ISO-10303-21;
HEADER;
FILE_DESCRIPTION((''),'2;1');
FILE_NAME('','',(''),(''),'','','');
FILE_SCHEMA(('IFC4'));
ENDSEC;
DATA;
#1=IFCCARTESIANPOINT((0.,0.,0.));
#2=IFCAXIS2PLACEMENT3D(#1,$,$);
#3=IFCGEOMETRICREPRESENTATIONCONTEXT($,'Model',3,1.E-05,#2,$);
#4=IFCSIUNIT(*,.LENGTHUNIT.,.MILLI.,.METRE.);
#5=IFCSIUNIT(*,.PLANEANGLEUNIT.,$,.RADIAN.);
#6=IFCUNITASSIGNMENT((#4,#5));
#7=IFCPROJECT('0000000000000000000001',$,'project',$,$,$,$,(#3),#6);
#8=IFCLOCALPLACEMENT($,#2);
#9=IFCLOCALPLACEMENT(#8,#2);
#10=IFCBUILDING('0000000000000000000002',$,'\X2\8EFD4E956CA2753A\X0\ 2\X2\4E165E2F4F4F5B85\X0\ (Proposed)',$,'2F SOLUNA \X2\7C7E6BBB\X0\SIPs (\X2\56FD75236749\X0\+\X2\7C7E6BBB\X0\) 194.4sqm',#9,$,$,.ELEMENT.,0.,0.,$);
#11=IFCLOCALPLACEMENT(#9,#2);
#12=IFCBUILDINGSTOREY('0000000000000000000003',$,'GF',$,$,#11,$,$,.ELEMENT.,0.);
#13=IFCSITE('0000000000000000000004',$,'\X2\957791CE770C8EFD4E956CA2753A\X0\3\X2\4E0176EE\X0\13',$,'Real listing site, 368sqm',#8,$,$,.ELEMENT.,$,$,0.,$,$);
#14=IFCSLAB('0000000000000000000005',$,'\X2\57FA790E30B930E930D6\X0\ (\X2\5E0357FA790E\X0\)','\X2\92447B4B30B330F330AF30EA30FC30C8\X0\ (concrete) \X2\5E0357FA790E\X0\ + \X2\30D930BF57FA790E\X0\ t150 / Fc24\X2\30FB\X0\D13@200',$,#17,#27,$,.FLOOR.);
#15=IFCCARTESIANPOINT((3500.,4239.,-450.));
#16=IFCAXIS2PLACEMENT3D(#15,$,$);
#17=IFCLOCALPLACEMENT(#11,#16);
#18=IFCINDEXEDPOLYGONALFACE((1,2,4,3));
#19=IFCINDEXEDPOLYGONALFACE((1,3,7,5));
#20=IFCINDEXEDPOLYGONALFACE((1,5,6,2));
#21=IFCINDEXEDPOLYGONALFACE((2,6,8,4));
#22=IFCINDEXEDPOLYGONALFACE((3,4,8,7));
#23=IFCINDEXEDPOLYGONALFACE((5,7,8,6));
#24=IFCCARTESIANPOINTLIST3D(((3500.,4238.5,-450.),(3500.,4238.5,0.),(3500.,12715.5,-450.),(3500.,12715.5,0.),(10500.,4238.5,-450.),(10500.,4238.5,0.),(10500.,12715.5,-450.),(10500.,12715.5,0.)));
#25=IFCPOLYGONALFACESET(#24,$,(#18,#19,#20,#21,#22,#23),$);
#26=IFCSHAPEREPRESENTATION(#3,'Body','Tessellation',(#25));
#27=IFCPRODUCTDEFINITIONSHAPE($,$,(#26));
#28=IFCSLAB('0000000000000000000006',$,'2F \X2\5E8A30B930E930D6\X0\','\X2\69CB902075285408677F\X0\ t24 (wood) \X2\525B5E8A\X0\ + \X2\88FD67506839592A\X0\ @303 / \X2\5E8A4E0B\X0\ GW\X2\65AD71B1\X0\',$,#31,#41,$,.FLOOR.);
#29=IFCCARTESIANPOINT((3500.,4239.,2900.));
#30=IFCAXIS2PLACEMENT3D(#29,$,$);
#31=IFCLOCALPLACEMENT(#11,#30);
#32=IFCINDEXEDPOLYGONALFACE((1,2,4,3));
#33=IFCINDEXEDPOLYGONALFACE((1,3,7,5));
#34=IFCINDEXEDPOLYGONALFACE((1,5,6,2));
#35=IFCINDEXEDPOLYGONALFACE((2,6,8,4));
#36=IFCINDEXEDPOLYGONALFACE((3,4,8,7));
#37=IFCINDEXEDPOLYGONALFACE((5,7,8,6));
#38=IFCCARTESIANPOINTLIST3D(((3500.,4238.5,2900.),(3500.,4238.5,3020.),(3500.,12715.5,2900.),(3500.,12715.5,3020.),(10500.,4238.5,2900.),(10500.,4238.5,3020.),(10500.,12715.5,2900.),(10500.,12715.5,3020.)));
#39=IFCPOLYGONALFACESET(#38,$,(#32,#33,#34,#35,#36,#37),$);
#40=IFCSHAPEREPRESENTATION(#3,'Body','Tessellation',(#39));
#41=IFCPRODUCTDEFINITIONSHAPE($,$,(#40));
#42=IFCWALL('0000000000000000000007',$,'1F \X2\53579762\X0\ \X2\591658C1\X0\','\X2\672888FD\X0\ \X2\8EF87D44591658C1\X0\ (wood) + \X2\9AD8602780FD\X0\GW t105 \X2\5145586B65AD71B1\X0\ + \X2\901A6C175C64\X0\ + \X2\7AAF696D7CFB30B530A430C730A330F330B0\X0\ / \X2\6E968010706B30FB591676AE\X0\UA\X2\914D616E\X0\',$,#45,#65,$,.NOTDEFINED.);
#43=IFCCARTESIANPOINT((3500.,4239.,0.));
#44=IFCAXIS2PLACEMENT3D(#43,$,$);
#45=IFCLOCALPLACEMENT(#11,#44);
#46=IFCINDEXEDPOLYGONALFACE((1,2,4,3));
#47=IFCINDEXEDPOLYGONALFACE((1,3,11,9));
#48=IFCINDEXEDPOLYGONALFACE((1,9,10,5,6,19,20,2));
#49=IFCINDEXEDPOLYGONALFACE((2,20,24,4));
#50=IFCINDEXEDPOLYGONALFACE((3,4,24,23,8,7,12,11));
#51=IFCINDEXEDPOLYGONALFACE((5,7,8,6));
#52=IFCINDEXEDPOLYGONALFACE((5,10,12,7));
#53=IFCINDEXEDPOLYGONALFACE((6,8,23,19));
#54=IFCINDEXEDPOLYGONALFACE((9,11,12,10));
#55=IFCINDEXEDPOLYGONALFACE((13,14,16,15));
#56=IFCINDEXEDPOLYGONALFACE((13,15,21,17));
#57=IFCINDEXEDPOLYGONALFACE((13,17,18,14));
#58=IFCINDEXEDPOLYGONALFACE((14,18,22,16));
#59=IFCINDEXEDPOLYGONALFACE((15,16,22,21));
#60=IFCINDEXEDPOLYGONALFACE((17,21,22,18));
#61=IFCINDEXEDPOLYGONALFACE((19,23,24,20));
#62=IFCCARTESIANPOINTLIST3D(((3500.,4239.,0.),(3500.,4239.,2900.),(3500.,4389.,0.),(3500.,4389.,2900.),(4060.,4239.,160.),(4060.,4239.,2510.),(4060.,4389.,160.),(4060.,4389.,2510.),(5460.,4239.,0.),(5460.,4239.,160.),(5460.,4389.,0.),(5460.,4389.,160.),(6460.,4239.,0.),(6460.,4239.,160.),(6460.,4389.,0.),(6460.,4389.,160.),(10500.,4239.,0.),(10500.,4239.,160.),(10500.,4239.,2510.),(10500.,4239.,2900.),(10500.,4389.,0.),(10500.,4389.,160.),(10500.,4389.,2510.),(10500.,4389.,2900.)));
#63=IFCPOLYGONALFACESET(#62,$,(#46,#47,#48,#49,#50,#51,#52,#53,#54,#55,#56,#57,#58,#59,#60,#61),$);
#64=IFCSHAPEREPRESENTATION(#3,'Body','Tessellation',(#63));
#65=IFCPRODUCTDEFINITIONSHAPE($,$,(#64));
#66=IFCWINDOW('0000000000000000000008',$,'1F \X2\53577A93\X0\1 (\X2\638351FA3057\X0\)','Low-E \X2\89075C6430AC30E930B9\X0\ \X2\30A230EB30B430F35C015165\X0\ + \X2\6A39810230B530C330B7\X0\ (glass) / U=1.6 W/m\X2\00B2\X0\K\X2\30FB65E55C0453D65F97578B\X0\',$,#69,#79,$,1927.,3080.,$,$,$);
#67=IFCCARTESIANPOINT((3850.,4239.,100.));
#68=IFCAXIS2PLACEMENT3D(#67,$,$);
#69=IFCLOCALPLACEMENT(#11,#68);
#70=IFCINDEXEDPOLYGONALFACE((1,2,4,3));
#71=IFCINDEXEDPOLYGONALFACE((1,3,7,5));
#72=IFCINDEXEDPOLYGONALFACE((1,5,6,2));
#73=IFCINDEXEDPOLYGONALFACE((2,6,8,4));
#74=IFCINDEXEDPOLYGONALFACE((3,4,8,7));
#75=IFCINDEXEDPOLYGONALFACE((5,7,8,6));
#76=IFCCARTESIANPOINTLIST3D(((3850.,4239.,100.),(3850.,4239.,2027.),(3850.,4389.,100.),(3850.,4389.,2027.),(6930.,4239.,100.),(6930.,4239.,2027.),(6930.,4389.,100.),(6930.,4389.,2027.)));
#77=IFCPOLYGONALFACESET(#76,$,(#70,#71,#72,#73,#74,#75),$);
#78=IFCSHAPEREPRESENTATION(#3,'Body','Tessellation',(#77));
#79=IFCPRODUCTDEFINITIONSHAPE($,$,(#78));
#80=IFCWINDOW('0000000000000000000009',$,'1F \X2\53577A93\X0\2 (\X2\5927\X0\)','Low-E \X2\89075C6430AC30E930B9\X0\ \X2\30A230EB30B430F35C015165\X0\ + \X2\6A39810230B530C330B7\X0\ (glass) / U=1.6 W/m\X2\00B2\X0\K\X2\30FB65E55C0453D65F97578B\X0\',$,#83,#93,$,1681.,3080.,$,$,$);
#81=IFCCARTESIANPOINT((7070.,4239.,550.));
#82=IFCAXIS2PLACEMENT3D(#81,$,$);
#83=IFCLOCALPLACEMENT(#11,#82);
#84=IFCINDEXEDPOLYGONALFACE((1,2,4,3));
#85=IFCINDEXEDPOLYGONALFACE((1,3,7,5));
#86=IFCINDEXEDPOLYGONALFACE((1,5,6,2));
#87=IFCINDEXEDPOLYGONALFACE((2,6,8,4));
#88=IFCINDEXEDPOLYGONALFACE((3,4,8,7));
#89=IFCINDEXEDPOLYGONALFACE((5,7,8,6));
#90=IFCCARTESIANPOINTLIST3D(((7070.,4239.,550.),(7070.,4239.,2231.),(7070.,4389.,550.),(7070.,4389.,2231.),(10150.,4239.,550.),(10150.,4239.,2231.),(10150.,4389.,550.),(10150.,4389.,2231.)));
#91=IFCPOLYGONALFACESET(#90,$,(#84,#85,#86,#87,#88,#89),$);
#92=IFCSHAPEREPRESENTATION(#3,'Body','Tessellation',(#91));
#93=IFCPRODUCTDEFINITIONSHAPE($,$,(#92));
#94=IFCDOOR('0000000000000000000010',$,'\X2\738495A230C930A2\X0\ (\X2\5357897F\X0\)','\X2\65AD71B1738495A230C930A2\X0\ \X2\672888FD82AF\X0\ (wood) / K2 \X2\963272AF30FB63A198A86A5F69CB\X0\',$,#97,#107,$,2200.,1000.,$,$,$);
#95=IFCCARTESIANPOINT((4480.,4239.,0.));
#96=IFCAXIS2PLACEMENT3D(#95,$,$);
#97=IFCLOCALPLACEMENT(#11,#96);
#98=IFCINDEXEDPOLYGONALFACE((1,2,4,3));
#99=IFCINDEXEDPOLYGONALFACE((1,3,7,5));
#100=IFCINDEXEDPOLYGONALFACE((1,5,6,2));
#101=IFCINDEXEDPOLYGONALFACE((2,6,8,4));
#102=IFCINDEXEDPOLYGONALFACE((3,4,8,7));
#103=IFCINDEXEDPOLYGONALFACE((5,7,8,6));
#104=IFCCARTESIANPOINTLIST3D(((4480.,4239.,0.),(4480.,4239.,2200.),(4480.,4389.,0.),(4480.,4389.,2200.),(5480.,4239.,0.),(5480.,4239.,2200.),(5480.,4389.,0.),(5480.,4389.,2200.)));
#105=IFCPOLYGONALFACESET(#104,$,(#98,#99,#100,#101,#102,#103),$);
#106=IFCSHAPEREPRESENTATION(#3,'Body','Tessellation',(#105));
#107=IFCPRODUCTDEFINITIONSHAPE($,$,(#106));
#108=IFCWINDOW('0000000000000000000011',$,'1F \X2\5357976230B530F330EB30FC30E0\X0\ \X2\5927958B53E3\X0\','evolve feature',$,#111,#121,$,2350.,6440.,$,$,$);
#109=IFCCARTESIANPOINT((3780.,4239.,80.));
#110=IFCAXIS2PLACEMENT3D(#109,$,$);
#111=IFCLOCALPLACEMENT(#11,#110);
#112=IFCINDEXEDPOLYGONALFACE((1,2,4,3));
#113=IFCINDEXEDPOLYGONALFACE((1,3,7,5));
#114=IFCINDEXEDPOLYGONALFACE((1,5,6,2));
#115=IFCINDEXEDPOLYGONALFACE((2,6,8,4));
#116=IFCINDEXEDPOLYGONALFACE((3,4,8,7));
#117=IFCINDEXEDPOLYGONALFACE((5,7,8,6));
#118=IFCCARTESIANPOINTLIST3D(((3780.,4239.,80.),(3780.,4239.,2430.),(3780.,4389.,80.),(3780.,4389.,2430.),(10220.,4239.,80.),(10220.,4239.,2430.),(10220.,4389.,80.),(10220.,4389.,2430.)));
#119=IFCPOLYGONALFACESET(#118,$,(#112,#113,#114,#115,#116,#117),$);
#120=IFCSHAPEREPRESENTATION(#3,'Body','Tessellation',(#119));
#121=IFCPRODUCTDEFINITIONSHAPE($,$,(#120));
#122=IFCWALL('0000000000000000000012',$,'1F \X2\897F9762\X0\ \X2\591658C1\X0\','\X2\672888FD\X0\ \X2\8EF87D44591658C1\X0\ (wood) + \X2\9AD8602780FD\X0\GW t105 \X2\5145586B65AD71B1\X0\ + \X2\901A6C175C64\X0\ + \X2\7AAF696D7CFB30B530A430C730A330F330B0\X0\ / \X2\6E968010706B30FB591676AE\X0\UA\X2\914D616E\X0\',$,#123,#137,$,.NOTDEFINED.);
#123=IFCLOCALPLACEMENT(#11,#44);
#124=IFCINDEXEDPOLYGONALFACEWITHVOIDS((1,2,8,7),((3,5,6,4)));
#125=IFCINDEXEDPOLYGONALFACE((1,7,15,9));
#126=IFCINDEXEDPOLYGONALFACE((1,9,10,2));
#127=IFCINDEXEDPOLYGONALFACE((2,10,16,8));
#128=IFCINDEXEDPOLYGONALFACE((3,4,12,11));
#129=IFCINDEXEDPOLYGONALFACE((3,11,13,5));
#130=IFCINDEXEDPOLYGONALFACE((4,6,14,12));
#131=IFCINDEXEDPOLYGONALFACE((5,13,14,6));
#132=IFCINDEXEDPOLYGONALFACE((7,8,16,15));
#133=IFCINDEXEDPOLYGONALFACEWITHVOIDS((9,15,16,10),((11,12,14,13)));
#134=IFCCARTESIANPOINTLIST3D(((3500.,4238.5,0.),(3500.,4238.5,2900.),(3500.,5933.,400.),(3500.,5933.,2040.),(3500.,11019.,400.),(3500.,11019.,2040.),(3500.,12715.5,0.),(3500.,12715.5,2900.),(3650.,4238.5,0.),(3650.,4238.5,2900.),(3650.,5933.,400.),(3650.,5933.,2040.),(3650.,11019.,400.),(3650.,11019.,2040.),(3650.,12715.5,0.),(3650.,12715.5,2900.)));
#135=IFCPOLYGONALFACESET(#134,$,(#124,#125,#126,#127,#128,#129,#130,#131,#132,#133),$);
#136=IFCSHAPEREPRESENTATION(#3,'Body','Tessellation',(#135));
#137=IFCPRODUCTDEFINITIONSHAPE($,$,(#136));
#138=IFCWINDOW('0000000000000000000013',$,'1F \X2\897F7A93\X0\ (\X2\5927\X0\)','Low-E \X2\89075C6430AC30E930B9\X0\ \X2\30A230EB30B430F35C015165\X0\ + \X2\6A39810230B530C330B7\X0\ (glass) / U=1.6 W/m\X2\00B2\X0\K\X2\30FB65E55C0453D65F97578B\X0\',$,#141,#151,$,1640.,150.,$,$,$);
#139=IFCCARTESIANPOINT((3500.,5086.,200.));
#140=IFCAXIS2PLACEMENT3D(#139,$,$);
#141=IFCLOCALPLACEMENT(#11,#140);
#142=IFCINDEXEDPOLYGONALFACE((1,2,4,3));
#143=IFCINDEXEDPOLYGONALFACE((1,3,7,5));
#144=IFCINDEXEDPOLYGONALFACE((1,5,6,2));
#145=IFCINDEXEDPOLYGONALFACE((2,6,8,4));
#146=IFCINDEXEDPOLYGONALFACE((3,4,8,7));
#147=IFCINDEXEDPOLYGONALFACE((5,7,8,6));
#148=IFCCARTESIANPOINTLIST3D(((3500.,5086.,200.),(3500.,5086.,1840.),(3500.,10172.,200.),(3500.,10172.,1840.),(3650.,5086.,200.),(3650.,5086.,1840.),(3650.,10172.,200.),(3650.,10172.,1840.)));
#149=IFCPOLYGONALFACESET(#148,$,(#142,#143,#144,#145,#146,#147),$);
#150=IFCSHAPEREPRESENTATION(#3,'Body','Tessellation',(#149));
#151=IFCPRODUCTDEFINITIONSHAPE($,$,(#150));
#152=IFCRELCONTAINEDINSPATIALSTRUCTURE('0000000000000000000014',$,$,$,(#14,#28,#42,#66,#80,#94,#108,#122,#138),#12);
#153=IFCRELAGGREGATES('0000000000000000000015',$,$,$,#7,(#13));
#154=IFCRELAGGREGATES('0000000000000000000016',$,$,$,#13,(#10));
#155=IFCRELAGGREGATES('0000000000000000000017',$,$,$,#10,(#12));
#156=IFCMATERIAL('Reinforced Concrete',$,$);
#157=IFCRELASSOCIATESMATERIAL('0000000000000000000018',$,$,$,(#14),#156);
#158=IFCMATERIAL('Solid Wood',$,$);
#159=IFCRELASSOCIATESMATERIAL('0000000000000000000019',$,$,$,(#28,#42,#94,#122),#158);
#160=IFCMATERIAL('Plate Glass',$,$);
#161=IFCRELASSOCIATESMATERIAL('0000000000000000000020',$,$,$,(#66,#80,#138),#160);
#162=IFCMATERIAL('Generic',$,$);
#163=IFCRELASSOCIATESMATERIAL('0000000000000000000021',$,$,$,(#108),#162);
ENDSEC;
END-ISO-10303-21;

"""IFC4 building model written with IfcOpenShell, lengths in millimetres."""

from ifc_helpers import new_model, si_unit, frame, frame_2d, origin, place, context, project, spatial, rectangle, extrude, material, element, fill, save


model = new_model("IFC4")

# Units and contexts
model_context = context("Model", 3, precision=1e-05, world=origin())
ifc_project = project(units=[si_unit("LENGTHUNIT", "METRE", prefix="MILLI"), si_unit("PLANEANGLEUNIT", "RADIAN")], contexts=[model_context])

# Site, building, storey
site_placement = place(None, origin())
site = spatial("IfcSite", under=ifc_project, at=site_placement, Name="長野県軽井沢町3丁目13", ObjectType="Real listing site, 368sqm", CompositionType="ELEMENT", RefElevation=0.0)
building_placement = place(site_placement, origin())
building = spatial("IfcBuilding", under=site, at=building_placement, Name="軽井沢町 2世帯住宅 (Proposed)", ObjectType="2F SOLUNA 籾殻SIPs (国産杉+籾殻) 194.4sqm", CompositionType="ELEMENT", ElevationOfRefHeight=0.0, ElevationOfTerrain=0.0)
storey_placement = place(building_placement, origin())
storey = spatial("IfcBuildingStorey", under=building, at=storey_placement, Name="GF", CompositionType="ELEMENT", Elevation=0.0)

# Slabs
ifc_material_1 = material(Name="Reinforced Concrete")
slab_1_placement = place(storey_placement, frame((3500.0, 4239.0, -450.0)))
element("IfcSlab", 1, at=slab_1_placement, inside=storey, material=ifc_material_1, Name="基礎スラブ (布基礎)", Description="鉄筋コンクリート (concrete) 布基礎 + ベタ基礎 t150 / Fc24・D13@200", PredefinedType="FLOOR", context=model_context, shape_type="SweptSolid", body=[
    extrude(rectangle(XDim=7000.0, YDim=8477.0, at=frame_2d((3500.0, 4238.0))), frame((3500.0, 4239.0, -450.0)), (0.0, 0.0, 1.0), 450.0),
])
ifc_material_2 = material(Name="Solid Wood")
slab_2_placement = place(storey_placement, frame((3500.0, 4239.0, 2900.0)))
element("IfcSlab", 2, at=slab_2_placement, inside=storey, material=ifc_material_2, Name="2F 床スラブ", Description="構造用合板 t24 (wood) 剛床 + 製材根太 @303 / 床下 GW断熱", PredefinedType="FLOOR", context=model_context, shape_type="SweptSolid", body=[
    extrude(rectangle(XDim=7000.0, YDim=8477.0, at=frame_2d((3500.0, 4238.0))), frame((3500.0, 4239.0, 2900.0)), (0.0, 0.0, 1.0), 120.0),
])
ifc_material_3 = material(Name="Generic")

# Wall, openings, windows, door
wall_1_placement = place(storey_placement, frame((3500.0, 4239.0, 0.0)))
wall_1 = element("IfcWall", 3, at=wall_1_placement, inside=storey, material=ifc_material_2, Name="1F 南面 外壁", Description="木製 軸組外壁 (wood) + 高性能GW t105 充填断熱 + 通気層 + 窯業系サイディング / 準耐火・外皮UA配慮", PredefinedType="NOTDEFINED", context=model_context, shape_type="SweptSolid", body=[
    extrude(rectangle(XDim=7000.0, YDim=150.0, at=frame_2d((3500.0, 75.0))), frame((3500.0, 4239.0, 0.0)), (0.0, 0.0, 1.0), 2900.0),
])
opening_1_placement = place(storey_placement, frame((3850.0, 4239.0, 100.0)))
opening_1 = element("IfcOpeningElement", 4, at=opening_1_placement, cuts=wall_1, PredefinedType="NOTDEFINED", context=model_context, shape_type="SweptSolid", body=[
    extrude(rectangle(XDim=3080.0, YDim=150.0, at=frame_2d((1540.0, 75.0))), frame((3850.0, 4239.0, 100.0)), (0.0, 0.0, 1.0), 1927.0),
])
opening_2_placement = place(storey_placement, frame((7070.0, 4239.0, 550.0)))
opening_2 = element("IfcOpeningElement", 5, at=opening_2_placement, cuts=wall_1, PredefinedType="NOTDEFINED", context=model_context, shape_type="SweptSolid", body=[
    extrude(rectangle(XDim=3080.0, YDim=150.0, at=frame_2d((1540.0, 75.0))), frame((7070.0, 4239.0, 550.0)), (0.0, 0.0, 1.0), 1681.0),
])
opening_3_placement = place(storey_placement, frame((4480.0, 4239.0, 0.0)))
opening_3 = element("IfcOpeningElement", 6, at=opening_3_placement, cuts=wall_1, PredefinedType="NOTDEFINED", context=model_context, shape_type="SweptSolid", body=[
    extrude(rectangle(XDim=1000.0, YDim=150.0, at=frame_2d((500.0, 75.0))), frame((4480.0, 4239.0, 0.0)), (0.0, 0.0, 1.0), 2200.0),
])
opening_4_placement = place(storey_placement, frame((3780.0, 4239.0, 80.0)))
opening_4 = element("IfcOpeningElement", 7, at=opening_4_placement, cuts=wall_1, PredefinedType="NOTDEFINED", context=model_context, shape_type="SweptSolid", body=[
    extrude(rectangle(XDim=6440.0, YDim=150.0, at=frame_2d((3220.0, 75.0))), frame((3780.0, 4239.0, 80.0)), (0.0, 0.0, 1.0), 2350.0),
])
ifc_material_4 = material(Name="Plate Glass")
window_1_placement = place(storey_placement, frame((3850.0, 4239.0, 100.0)))
window_1 = element("IfcWindow", 8, at=window_1_placement, inside=storey, material=ifc_material_4, Name="1F 南窓1 (掃出し)", Description="Low-E 複層ガラス アルゴン封入 + 樹脂サッシ (glass) / U=1.6 W/m²K・日射取得型", OverallHeight=1927.0, OverallWidth=3080.0, context=model_context, shape_type="SweptSolid", body=[
    extrude(rectangle(XDim=3080.0, YDim=150.0, at=frame_2d((1540.0, 75.0))), frame((3850.0, 4239.0, 100.0)), (0.0, 0.0, 1.0), 1927.0),
])
fill(opening_1, window_1)
window_2_placement = place(storey_placement, frame((7070.0, 4239.0, 550.0)))
window_2 = element("IfcWindow", 9, at=window_2_placement, inside=storey, material=ifc_material_4, Name="1F 南窓2 (大)", Description="Low-E 複層ガラス アルゴン封入 + 樹脂サッシ (glass) / U=1.6 W/m²K・日射取得型", OverallHeight=1681.0, OverallWidth=3080.0, context=model_context, shape_type="SweptSolid", body=[
    extrude(rectangle(XDim=3080.0, YDim=150.0, at=frame_2d((1540.0, 75.0))), frame((7070.0, 4239.0, 550.0)), (0.0, 0.0, 1.0), 1681.0),
])
fill(opening_2, window_2)
door_placement = place(storey_placement, frame((4480.0, 4239.0, 0.0)))
door = element("IfcDoor", 10, at=door_placement, inside=storey, material=ifc_material_2, Name="玄関ドア (南西)", Description="断熱玄関ドア 木製芯 (wood) / K2 防犯・採風機構", OverallHeight=2200.0, OverallWidth=1000.0, context=model_context, shape_type="SweptSolid", body=[
    extrude(rectangle(XDim=1000.0, YDim=150.0, at=frame_2d((500.0, 75.0))), frame((4480.0, 4239.0, 0.0)), (0.0, 0.0, 1.0), 2200.0),
])
fill(opening_3, door)
window_3_placement = place(storey_placement, frame((3780.0, 4239.0, 80.0)))
window_3 = element("IfcWindow", 11, at=window_3_placement, inside=storey, material=ifc_material_3, Name="1F 南面サンルーム 大開口", Description="evolve feature", OverallHeight=2350.0, OverallWidth=6440.0, context=model_context, shape_type="SweptSolid", body=[
    extrude(rectangle(XDim=6440.0, YDim=150.0, at=frame_2d((3220.0, 75.0))), frame((3780.0, 4239.0, 80.0)), (0.0, 0.0, 1.0), 2350.0),
])
fill(opening_4, window_3)

# Wall, opening, window
wall_2_placement = place(storey_placement, frame((3500.0, 4239.0, 0.0)))
wall_2 = element("IfcWall", 12, at=wall_2_placement, inside=storey, material=ifc_material_2, Name="1F 西面 外壁", Description="木製 軸組外壁 (wood) + 高性能GW t105 充填断熱 + 通気層 + 窯業系サイディング / 準耐火・外皮UA配慮", PredefinedType="NOTDEFINED", context=model_context, shape_type="SweptSolid", body=[
    extrude(rectangle(XDim=150.0, YDim=8477.0, at=frame_2d((75.0, 4238.0))), frame((3500.0, 4239.0, 0.0)), (0.0, 0.0, 1.0), 2900.0),
])
opening_5_placement = place(storey_placement, frame((3500.0, 5086.0, 200.0)))
opening_5 = element("IfcOpeningElement", 13, at=opening_5_placement, cuts=wall_2, PredefinedType="NOTDEFINED", context=model_context, shape_type="SweptSolid", body=[
    extrude(rectangle(XDim=150.0, YDim=5086.0, at=frame_2d((75.0, 2543.0))), frame((3500.0, 5086.0, 200.0)), (0.0, 0.0, 1.0), 1640.0),
])
window_4_placement = place(storey_placement, frame((3500.0, 5086.0, 200.0)))
window_4 = element("IfcWindow", 14, at=window_4_placement, inside=storey, material=ifc_material_4, Name="1F 西窓 (大)", Description="Low-E 複層ガラス アルゴン封入 + 樹脂サッシ (glass) / U=1.6 W/m²K・日射取得型", OverallHeight=1640.0, OverallWidth=150.0, context=model_context, shape_type="SweptSolid", body=[
    extrude(rectangle(XDim=150.0, YDim=5086.0, at=frame_2d((75.0, 2543.0))), frame((3500.0, 5086.0, 200.0)), (0.0, 0.0, 1.0), 1640.0),
])
fill(opening_5, window_4)

save(model, "model.ifc")
